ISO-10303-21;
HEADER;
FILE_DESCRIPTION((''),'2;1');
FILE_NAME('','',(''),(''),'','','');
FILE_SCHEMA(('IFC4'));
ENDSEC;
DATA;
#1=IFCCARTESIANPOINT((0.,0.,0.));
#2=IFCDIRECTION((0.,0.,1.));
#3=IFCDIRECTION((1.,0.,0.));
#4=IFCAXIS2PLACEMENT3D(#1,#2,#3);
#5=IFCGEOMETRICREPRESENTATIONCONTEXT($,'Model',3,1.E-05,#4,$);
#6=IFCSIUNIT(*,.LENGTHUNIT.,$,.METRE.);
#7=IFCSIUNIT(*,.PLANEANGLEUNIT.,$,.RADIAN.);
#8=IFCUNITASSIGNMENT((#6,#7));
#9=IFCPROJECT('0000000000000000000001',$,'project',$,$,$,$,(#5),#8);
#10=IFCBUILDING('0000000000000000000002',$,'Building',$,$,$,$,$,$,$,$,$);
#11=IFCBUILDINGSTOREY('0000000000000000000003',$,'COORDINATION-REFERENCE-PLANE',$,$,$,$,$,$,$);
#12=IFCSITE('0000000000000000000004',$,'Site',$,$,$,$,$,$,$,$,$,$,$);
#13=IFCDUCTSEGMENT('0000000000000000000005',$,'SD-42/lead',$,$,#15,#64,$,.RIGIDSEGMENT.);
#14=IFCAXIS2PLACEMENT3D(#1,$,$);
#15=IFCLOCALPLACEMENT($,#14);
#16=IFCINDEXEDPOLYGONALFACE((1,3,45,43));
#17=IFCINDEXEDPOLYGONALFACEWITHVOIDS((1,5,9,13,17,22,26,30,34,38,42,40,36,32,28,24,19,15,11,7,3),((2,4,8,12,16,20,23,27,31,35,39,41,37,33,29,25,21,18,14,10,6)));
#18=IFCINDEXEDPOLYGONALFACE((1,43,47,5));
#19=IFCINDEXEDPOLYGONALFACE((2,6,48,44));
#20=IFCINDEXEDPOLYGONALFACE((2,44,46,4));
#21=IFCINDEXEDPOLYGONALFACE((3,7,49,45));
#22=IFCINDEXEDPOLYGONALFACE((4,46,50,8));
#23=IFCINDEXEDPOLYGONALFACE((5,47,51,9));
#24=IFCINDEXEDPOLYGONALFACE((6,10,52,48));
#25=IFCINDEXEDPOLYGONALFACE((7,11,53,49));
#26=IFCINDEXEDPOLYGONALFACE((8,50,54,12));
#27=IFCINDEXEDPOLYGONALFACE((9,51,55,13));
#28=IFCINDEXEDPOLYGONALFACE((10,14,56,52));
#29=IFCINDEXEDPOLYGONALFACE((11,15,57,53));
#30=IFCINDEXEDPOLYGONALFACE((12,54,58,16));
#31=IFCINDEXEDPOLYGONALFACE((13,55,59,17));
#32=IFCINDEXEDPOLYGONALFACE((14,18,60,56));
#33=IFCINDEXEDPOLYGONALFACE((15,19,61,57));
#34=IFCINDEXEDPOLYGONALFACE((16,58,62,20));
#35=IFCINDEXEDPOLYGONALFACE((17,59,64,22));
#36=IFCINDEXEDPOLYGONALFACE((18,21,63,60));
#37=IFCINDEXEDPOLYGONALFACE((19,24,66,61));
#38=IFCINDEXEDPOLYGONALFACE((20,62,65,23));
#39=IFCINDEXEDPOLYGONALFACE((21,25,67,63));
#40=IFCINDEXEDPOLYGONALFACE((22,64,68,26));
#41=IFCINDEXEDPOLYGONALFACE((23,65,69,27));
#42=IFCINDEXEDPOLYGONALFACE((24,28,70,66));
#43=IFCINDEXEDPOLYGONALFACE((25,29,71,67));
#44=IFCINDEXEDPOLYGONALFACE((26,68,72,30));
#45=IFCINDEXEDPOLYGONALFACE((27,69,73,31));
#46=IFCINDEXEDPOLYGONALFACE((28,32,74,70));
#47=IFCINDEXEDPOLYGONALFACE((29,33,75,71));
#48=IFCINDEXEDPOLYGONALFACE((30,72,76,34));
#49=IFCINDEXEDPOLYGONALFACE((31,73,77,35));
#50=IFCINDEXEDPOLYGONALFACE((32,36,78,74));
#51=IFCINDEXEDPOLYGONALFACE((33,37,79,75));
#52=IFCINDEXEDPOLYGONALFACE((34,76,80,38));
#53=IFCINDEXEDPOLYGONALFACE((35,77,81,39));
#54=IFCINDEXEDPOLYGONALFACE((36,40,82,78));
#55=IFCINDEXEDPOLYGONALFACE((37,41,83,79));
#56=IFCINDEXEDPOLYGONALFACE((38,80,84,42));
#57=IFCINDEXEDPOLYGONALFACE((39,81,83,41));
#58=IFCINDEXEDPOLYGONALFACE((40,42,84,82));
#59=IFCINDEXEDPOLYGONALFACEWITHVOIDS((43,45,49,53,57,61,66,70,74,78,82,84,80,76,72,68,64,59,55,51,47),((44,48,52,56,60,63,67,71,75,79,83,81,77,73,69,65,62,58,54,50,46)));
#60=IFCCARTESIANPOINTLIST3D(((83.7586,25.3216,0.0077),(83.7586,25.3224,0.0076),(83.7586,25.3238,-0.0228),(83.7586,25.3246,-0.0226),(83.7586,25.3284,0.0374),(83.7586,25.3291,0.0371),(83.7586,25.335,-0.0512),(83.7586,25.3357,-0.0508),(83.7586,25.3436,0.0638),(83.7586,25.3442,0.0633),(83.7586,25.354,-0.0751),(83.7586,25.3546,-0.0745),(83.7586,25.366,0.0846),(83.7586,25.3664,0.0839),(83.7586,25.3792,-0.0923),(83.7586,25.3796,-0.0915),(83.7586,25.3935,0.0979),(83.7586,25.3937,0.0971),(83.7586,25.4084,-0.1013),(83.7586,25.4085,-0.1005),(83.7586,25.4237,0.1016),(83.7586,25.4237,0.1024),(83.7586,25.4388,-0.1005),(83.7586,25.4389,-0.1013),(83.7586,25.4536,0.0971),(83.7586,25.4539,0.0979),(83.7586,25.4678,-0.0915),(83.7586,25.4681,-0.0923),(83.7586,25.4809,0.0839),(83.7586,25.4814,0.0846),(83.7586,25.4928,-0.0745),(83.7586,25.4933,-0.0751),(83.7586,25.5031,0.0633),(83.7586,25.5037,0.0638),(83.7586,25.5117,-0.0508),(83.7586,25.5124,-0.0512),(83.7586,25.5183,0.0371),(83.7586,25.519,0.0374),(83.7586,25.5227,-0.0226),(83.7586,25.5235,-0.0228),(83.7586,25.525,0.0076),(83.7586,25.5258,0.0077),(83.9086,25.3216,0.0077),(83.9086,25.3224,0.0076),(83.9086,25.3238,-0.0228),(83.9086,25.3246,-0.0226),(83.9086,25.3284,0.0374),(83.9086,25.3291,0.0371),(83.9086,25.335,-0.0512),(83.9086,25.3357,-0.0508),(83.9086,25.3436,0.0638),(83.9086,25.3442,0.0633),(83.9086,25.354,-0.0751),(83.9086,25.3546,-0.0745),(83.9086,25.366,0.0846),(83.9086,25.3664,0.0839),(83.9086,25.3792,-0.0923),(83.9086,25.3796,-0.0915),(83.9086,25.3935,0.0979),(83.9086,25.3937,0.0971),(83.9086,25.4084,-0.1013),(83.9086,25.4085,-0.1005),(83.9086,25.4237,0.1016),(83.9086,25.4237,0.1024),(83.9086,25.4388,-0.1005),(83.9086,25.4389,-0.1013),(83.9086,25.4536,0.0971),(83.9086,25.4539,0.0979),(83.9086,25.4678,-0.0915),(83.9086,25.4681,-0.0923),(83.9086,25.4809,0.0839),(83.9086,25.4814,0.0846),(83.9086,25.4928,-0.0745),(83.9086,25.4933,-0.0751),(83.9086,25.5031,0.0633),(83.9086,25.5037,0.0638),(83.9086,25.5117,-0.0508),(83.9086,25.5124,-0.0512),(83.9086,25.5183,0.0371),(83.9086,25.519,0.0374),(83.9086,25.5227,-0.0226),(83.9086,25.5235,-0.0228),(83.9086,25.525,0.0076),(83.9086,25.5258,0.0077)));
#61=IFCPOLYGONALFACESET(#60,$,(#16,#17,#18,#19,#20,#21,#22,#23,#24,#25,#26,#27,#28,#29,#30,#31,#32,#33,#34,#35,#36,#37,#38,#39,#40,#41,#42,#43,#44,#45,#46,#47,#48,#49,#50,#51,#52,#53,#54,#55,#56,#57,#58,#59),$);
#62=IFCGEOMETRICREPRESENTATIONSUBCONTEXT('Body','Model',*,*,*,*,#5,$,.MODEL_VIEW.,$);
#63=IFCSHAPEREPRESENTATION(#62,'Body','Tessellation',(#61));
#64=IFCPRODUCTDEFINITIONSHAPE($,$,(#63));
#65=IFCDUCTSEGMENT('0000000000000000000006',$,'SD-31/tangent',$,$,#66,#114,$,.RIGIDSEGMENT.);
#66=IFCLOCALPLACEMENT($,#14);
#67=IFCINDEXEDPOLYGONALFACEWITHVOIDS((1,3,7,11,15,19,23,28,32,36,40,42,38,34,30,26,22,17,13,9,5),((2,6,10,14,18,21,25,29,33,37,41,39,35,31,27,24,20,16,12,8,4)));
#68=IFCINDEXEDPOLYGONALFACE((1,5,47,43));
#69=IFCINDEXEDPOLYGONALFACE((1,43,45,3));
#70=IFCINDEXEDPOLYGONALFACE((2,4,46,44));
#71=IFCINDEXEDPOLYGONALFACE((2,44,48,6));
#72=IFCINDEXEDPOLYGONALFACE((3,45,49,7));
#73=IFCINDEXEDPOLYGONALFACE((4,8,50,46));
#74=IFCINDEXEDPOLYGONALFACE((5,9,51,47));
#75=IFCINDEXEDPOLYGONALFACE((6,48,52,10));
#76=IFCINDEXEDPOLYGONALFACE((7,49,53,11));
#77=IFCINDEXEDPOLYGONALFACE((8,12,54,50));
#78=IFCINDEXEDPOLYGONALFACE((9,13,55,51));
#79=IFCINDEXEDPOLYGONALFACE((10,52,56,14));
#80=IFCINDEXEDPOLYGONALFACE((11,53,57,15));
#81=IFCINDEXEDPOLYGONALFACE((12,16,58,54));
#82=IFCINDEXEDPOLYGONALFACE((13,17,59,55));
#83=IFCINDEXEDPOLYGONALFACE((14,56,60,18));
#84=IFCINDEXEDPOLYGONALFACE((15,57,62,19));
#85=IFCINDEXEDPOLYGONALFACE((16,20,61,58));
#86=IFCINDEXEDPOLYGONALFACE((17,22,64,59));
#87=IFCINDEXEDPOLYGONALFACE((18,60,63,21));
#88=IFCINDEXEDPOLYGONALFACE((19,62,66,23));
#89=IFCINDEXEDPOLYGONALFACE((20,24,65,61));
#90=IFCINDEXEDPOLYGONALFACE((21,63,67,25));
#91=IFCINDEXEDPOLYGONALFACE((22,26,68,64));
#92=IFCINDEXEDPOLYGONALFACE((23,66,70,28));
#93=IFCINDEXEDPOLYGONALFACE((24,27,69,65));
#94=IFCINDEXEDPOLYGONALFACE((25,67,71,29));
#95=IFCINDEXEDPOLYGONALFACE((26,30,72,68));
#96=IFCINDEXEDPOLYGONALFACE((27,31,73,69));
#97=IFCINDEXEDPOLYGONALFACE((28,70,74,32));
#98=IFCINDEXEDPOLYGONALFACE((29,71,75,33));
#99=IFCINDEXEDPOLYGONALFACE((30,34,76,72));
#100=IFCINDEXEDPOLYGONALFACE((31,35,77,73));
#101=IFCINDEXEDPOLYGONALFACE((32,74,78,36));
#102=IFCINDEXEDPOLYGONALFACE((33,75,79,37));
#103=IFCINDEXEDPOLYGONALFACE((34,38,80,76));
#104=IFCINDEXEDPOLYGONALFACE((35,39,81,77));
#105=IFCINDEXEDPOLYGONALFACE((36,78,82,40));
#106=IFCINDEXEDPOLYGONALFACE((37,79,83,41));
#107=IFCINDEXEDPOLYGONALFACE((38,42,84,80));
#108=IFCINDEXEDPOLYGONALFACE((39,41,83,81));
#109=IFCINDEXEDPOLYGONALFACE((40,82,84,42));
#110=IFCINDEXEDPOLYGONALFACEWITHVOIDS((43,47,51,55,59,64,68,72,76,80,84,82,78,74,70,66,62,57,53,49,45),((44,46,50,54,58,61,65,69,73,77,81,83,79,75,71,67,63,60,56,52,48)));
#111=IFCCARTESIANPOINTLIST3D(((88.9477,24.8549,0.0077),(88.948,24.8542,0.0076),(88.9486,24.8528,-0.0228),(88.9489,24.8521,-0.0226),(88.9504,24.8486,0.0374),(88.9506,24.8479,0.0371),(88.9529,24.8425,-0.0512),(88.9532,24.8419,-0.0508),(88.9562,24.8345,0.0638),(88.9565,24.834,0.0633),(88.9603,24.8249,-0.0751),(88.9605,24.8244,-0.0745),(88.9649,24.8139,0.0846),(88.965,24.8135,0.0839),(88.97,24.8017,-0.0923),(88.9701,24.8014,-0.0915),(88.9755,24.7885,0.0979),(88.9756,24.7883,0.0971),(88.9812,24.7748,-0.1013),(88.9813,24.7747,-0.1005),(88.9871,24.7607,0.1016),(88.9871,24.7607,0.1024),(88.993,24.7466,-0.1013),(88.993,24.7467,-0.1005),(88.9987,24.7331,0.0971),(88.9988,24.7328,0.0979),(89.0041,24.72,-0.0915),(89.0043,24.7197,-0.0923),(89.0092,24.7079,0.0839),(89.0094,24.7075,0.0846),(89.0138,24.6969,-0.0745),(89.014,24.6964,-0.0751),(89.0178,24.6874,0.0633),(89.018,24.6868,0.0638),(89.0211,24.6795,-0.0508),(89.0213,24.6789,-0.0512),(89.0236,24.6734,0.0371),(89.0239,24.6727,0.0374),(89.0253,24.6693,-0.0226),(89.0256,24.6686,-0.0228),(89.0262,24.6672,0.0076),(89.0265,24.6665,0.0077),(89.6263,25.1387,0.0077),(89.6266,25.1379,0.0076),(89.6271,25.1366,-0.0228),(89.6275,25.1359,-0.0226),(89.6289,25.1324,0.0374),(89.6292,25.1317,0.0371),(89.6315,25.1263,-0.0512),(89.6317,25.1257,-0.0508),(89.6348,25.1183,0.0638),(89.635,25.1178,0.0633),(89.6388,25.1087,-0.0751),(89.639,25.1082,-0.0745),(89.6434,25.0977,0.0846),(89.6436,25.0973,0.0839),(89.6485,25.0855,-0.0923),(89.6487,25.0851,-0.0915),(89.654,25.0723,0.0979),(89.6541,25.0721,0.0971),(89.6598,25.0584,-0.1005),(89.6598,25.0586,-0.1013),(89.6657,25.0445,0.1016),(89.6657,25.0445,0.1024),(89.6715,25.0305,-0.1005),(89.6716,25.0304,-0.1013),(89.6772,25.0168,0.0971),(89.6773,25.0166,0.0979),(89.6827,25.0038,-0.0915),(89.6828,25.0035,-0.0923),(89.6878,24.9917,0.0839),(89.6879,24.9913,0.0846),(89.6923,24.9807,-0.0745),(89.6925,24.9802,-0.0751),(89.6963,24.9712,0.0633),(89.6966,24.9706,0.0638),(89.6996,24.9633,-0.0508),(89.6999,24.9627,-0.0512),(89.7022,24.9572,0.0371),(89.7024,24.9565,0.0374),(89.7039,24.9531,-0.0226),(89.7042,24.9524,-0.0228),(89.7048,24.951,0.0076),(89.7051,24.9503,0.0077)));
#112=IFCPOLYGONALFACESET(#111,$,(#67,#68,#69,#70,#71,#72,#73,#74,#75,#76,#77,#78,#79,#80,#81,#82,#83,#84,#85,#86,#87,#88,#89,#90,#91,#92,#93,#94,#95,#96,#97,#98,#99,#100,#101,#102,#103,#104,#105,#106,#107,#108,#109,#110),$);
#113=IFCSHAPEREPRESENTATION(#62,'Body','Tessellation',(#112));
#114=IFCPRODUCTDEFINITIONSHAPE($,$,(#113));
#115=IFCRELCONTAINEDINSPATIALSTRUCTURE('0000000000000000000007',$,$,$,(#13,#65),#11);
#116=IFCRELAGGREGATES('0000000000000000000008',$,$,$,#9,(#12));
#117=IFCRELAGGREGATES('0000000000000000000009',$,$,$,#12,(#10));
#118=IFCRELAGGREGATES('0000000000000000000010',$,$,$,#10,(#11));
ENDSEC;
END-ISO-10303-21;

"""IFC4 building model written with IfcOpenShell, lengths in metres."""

from ifc_helpers import new_model, si_unit, frame, origin_with_axes, place, context, subcontext, project, spatial, hollow_circle, extrude, element, save


model = new_model("IFC4")

# Units and contexts
model_context = context("Model", 3, precision=1e-05, world=origin_with_axes())
body_context_1 = subcontext(model_context, "Body", "Model", "MODEL_VIEW")
ifc_project = project(units=[si_unit("LENGTHUNIT", "METRE"), si_unit("PLANEANGLEUNIT", "RADIAN")], contexts=[model_context])

# Site, building, storey
site = spatial("IfcSite", under=ifc_project, Name="Site")
building = spatial("IfcBuilding", under=site, Name="Building")
storey = spatial("IfcBuildingStorey", under=building, Name="COORDINATION-REFERENCE-PLANE")

# Duct segment
duct_segment_1_placement = place(None, frame((83.7586, 25.4237, 0.0), z_axis=(1.0, 0.0, 0.0), x_axis=(0.0, 0.0, 1.0)))
element("IfcDuctSegment", 1, at=duct_segment_1_placement, inside=storey, Name="SD-42/lead", PredefinedType="RIGIDSEGMENT", context=body_context_1, shape_type="SweptSolid", body=[
    extrude(hollow_circle(Radius=0.1024, WallThickness=0.0008), origin_with_axes(), (0.0, 0.0, 1.0), 0.15),
])

# Duct segment
duct_segment_2_placement = place(None, frame((89.6657, 25.0445, 0.0), z_axis=(-0.922564, -0.385845, 0.0), x_axis=(0.0, 0.0, 1.0)))
element("IfcDuctSegment", 2, at=duct_segment_2_placement, inside=storey, Name="SD-31/tangent", PredefinedType="RIGIDSEGMENT", context=body_context_1, shape_type="SweptSolid", body=[
    extrude(hollow_circle(Radius=0.1024, WallThickness=0.0008), origin_with_axes(), (0.0, 0.0, 1.0), 0.7355),
])

save(model, "model.ifc")
